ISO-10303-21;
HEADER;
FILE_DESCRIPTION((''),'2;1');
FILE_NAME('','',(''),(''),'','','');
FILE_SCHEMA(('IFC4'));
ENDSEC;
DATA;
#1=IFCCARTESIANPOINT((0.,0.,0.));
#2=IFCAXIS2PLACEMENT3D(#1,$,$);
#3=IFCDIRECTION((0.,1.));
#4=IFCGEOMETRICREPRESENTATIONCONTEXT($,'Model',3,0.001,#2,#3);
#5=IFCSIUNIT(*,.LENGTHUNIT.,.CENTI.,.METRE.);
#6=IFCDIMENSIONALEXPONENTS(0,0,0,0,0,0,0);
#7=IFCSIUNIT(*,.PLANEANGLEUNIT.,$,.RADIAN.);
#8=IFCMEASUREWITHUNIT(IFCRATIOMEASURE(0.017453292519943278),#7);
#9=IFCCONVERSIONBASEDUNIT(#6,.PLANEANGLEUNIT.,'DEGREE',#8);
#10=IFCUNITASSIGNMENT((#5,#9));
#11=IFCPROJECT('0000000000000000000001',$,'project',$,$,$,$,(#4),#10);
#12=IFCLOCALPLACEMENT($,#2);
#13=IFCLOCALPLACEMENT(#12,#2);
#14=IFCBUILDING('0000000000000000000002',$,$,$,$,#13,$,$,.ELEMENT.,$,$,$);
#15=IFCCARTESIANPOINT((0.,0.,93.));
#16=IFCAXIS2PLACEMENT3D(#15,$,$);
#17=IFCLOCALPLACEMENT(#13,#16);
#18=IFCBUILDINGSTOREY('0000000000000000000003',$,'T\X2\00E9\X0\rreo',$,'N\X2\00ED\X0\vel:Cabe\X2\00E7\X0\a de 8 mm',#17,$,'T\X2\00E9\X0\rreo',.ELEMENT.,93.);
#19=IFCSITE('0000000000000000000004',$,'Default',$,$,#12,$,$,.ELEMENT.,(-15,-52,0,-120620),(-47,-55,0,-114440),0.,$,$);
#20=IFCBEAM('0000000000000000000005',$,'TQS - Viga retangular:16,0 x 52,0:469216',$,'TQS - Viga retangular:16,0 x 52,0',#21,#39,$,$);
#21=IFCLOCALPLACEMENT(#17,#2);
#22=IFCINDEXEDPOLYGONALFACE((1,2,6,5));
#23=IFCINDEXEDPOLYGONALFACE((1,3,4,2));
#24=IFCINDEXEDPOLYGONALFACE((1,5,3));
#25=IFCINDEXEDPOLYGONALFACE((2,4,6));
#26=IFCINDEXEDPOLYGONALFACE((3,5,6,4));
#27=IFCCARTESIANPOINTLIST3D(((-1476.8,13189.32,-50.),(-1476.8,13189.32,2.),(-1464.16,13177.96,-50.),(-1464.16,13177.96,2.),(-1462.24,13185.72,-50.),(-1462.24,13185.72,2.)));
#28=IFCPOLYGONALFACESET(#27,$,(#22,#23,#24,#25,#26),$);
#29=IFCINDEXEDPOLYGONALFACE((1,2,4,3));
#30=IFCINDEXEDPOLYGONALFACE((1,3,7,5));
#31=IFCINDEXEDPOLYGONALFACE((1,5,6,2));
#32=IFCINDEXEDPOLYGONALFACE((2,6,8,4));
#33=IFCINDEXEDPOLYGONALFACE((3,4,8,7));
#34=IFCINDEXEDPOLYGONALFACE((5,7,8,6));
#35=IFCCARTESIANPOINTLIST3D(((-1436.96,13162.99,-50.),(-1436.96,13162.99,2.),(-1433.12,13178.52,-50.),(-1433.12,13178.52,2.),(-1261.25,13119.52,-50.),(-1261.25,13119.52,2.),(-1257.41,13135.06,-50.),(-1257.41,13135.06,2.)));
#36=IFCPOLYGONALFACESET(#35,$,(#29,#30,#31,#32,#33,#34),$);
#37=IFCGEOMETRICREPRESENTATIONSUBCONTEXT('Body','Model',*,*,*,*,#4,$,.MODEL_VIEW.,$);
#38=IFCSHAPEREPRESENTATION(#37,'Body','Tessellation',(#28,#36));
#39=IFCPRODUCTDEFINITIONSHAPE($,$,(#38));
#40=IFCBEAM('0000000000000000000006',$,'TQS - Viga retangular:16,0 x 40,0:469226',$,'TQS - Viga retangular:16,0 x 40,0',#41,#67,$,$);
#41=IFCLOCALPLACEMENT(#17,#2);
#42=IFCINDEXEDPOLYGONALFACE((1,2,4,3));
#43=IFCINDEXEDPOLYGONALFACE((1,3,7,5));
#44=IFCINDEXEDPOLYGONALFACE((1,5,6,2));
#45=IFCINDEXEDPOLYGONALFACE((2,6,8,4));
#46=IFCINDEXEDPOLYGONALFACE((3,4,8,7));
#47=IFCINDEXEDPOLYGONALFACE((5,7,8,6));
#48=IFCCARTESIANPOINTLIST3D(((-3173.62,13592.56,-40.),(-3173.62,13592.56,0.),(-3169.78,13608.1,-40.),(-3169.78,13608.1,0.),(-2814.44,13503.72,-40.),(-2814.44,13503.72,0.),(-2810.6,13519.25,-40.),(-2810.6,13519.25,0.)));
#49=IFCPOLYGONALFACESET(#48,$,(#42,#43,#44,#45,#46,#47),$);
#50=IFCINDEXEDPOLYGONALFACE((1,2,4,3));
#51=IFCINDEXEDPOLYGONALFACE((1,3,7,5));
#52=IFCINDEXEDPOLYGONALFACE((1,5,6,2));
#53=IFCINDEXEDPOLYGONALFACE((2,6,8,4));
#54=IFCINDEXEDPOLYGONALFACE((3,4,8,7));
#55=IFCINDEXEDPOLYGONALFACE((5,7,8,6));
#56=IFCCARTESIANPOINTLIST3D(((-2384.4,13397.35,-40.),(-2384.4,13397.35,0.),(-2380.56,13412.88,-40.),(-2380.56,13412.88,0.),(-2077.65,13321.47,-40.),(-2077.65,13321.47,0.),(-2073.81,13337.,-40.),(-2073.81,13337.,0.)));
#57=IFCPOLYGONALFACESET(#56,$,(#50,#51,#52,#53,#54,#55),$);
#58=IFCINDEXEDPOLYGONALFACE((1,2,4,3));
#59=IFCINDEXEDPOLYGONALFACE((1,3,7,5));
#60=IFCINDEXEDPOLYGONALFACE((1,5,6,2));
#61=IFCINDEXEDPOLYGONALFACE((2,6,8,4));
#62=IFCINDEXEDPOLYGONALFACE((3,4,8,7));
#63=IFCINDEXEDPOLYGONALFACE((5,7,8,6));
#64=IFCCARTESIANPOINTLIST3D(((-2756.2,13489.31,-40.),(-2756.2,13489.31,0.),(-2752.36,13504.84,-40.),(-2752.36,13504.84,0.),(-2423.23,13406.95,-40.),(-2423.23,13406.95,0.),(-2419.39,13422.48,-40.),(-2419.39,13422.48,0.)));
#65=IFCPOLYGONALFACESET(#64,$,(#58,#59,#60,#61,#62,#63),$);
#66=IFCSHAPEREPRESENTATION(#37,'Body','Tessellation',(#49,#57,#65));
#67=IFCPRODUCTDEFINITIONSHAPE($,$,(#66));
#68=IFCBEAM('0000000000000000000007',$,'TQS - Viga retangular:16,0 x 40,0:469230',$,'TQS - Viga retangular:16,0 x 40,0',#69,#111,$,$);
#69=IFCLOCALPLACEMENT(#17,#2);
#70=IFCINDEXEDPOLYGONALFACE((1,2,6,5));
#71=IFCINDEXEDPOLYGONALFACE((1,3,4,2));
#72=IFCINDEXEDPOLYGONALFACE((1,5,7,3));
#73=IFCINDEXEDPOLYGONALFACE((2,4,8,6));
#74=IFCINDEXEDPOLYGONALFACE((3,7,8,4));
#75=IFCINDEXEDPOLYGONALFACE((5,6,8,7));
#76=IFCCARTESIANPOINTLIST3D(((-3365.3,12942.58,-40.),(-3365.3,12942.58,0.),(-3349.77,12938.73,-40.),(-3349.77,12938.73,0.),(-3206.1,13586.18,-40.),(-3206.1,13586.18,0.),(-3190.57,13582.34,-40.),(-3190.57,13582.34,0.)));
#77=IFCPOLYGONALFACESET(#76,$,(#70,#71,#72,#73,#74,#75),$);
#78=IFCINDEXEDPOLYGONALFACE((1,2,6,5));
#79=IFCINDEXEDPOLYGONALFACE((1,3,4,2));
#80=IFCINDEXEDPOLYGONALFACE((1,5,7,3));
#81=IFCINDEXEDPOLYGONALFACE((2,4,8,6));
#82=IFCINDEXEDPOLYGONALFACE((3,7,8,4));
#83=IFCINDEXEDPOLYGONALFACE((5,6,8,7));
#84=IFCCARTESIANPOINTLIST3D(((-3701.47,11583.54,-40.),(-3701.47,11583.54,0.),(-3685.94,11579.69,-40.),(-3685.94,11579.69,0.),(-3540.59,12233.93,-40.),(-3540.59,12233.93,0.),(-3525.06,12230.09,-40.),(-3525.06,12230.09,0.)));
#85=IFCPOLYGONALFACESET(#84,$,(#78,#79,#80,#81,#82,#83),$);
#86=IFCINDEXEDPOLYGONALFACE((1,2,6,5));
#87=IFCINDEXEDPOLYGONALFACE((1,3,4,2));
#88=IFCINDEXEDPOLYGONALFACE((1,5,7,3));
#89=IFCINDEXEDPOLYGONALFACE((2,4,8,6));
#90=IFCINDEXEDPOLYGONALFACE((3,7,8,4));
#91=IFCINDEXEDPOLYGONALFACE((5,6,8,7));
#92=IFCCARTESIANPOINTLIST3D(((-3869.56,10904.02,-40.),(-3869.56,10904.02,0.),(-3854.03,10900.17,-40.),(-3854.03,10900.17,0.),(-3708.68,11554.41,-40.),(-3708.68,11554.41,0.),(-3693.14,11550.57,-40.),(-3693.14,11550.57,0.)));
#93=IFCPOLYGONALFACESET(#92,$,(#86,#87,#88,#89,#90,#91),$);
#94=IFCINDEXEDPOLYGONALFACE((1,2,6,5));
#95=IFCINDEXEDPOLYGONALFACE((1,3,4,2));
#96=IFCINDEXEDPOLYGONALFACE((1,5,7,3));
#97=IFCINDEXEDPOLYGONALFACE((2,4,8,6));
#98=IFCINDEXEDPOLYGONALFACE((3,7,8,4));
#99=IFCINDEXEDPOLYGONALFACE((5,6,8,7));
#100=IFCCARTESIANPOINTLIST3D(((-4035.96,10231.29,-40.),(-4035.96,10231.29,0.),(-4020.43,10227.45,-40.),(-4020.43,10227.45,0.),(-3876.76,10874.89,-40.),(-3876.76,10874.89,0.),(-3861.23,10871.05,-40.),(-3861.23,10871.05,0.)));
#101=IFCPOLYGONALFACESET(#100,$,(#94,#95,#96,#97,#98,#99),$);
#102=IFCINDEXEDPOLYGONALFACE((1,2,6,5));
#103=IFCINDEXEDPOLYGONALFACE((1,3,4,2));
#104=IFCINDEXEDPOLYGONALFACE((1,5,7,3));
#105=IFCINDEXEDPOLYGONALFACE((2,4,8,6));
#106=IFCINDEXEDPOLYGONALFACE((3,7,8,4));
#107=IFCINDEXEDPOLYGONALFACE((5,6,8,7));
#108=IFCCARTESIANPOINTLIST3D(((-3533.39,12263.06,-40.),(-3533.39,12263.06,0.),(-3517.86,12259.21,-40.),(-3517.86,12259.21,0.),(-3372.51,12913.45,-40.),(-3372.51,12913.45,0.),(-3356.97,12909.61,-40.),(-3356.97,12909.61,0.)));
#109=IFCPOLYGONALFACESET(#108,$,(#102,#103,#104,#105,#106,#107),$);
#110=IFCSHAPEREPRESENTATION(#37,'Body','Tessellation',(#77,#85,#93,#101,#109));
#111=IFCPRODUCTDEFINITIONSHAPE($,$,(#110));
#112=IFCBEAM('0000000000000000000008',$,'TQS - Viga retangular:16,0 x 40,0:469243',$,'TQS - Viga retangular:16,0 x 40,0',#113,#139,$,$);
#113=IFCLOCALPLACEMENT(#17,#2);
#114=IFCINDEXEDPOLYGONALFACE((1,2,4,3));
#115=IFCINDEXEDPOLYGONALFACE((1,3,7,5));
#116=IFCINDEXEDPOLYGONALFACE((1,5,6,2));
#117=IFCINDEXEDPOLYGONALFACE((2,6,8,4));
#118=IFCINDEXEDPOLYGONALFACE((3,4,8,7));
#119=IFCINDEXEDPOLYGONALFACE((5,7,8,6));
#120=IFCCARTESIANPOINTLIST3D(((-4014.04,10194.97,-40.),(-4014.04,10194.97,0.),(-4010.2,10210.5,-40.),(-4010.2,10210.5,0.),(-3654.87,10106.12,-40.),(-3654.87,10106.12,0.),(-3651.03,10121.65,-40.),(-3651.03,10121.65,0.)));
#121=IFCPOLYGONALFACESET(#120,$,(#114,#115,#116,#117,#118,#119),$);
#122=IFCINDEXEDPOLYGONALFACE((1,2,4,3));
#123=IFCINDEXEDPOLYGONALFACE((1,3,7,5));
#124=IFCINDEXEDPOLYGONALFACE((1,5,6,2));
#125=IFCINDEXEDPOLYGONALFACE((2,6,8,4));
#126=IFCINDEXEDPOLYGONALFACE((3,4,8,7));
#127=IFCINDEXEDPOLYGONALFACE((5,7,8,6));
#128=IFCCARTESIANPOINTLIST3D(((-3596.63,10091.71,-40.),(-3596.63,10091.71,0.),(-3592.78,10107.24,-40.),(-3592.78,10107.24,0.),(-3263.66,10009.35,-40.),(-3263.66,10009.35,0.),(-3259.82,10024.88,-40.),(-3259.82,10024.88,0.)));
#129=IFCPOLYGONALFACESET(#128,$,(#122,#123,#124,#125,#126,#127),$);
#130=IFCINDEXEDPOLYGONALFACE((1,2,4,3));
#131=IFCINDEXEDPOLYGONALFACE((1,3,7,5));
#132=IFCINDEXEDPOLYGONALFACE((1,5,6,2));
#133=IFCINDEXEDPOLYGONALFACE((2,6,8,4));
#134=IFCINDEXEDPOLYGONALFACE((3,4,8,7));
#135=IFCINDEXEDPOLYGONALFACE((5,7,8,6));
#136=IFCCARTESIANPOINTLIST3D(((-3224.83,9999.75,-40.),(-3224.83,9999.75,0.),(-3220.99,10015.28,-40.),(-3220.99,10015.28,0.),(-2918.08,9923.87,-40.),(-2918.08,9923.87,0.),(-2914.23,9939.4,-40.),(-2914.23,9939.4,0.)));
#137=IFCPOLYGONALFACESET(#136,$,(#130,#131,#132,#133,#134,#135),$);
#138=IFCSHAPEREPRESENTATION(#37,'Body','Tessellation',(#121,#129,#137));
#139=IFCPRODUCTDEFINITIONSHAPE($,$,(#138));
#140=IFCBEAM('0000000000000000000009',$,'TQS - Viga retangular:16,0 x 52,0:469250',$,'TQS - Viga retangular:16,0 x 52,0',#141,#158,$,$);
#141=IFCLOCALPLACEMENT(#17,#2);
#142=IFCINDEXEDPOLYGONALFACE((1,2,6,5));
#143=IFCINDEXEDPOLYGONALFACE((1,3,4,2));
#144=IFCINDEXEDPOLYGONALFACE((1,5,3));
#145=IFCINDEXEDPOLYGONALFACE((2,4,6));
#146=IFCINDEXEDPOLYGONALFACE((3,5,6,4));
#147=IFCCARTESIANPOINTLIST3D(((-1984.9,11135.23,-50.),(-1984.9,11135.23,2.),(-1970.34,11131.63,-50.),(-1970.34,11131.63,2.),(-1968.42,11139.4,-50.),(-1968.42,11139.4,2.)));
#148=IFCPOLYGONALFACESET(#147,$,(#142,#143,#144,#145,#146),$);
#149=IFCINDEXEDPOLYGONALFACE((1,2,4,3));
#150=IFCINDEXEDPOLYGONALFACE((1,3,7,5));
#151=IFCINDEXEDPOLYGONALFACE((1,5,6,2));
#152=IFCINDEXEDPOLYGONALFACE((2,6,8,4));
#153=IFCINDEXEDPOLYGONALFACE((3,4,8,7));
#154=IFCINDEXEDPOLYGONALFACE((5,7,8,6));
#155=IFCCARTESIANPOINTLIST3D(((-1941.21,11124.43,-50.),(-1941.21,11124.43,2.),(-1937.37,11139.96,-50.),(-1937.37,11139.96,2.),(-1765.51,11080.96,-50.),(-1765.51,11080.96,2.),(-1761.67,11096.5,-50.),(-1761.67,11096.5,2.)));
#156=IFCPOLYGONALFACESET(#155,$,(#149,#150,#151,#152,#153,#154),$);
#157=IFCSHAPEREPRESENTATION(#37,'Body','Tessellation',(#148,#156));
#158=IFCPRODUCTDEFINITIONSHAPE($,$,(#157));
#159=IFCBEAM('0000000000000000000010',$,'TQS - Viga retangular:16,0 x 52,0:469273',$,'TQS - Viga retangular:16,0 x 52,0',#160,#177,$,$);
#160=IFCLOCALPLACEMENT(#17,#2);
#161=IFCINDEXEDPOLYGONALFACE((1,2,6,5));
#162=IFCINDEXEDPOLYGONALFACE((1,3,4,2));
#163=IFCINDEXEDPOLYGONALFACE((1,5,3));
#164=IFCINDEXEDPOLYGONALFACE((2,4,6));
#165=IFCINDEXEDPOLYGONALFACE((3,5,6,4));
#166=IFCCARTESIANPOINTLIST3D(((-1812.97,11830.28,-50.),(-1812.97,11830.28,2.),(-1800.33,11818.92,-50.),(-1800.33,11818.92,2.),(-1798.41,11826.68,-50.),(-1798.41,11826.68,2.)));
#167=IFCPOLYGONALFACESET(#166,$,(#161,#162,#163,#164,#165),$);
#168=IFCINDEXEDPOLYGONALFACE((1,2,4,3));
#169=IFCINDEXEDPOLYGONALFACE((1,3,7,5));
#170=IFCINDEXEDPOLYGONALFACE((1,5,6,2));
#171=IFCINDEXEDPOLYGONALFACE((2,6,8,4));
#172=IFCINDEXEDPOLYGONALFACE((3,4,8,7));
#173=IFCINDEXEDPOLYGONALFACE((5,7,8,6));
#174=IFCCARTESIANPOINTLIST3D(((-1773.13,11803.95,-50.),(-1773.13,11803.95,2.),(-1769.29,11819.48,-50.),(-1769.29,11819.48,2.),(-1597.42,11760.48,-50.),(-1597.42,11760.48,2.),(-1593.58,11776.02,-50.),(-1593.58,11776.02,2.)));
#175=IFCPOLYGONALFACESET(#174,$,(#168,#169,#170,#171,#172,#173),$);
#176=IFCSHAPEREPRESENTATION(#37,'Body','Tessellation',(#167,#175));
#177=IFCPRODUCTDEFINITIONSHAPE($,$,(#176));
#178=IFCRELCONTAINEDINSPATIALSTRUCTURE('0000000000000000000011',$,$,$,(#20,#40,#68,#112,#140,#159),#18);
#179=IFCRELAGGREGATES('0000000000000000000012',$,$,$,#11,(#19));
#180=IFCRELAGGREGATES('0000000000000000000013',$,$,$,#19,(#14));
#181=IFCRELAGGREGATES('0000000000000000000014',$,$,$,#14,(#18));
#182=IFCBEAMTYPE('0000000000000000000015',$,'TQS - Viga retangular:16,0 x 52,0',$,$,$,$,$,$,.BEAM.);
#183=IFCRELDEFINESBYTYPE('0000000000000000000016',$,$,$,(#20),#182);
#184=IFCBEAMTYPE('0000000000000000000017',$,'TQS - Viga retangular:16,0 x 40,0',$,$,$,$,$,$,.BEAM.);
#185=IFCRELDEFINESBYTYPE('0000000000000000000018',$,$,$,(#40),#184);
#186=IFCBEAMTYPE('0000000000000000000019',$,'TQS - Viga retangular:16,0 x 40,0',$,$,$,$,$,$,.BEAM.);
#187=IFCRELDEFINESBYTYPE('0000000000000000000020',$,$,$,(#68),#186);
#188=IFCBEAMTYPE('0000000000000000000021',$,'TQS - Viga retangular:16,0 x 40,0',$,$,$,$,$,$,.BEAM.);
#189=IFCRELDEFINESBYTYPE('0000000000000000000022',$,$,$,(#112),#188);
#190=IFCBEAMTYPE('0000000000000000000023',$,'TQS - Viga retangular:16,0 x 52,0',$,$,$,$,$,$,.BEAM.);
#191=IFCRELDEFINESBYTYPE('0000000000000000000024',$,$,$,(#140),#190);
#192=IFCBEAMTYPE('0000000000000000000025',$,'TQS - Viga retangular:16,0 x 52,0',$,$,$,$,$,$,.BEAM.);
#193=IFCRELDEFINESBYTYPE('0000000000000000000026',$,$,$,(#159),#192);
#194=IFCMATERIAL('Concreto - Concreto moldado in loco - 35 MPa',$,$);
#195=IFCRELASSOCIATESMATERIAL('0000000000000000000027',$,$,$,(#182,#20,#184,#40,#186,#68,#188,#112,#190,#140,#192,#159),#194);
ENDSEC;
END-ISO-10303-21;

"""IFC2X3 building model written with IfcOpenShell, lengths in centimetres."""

from ifc_helpers import new_model, entity, si_unit, converted_unit, direction, frame, frame_2d, origin, place, context, subcontext, project, spatial, rectangle, extrude, clip, halfspace, source, transform, mapped, material, type_object, type_shapes, element, save


model = new_model("IFC2X3")

# Units and contexts
model_context = context("Model", 3, precision=0.001, world=origin(), true_north=direction((0.0, 1.0)))
body_context = subcontext(model_context, "Body", "Model", "MODEL_VIEW")
ifc_project = project(units=[si_unit("LENGTHUNIT", "METRE", prefix="CENTI"), converted_unit("PLANEANGLEUNIT", "DEGREE", entity("IfcRatioMeasure", 0.017453292519943278), si_unit("PLANEANGLEUNIT", "RADIAN"), dimensions=[0, 0, 0, 0, 0, 0, 0])], contexts=[model_context])

# Site, building, storey
site_placement = place(None, origin())
site = spatial("IfcSite", under=ifc_project, at=site_placement, Name="Default", CompositionType="ELEMENT", RefLatitude=(-15, -52, 0, -120620), RefLongitude=(-47, -55, 0, -114440), RefElevation=0.0)
building_placement = place(site_placement, origin())
building = spatial("IfcBuilding", under=site, at=building_placement, CompositionType="ELEMENT")
storey_placement = place(building_placement, frame((0.0, 0.0, 93.0)))
storey = spatial("IfcBuildingStorey", under=building, at=storey_placement, Name="Térreo", ObjectType="Nível:Cabeça de 8 mm", LongName="Térreo", CompositionType="ELEMENT", Elevation=93.0)

# Beams
ifc_material = material(Name="Concreto - Concreto moldado in loco - 35 MPa")
beam_type_1 = type_object("IfcBeamType", Name="TQS - Viga retangular:16,0 x 52,0", PredefinedType="BEAM", material=ifc_material)
shared_shape_1 = source(origin(), body_context, "Body", "SweptSolid", [
    clip(extrude(rectangle(XDim=52.0, YDim=8.0, at=frame_2d((0.0, 0.0), x_axis=(0.0, 1.0))), frame((-1463.2, 13181.84, 69.0), z_axis=(-0.970743, 0.240122, 0.0), x_axis=(0.240122, 0.970743, 0.0)), (0.0, 0.0, 1.0), 15.0), halfspace(frame((-1451.52, 13166.59, 95.0), z_axis=(-0.668693, -0.743539, 0.0), x_axis=(0.743539, -0.668693, 0.0)), False)),
    extrude(rectangle(XDim=52.0, YDim=16.0, at=frame_2d((0.0, 0.0), x_axis=(1.0, 0.0))), frame((-1259.33, 13127.29, 69.0), z_axis=(-0.970743, 0.240122, 0.0), x_axis=(0.0, 0.0, 1.0)), (0.0, 0.0, 1.0), 181.0),
])
type_shapes(beam_type_1, [shared_shape_1])
beam_1_placement = place(storey_placement, frame((0.0, 0.0, -93.0)))
element("IfcBeam", 1, at=beam_1_placement, inside=storey, type_object=beam_type_1, material=ifc_material, Name="TQS - Viga retangular:16,0 x 52,0:469216", ObjectType="TQS - Viga retangular:16,0 x 52,0", context=body_context, shape_type="MappedRepresentation", body=[
    mapped(shared_shape_1, transform((0.0, 0.0, 0.0), scale=1.0)),
])
beam_type_2 = type_object("IfcBeamType", Name="TQS - Viga retangular:16,0 x 40,0", PredefinedType="BEAM", material=ifc_material)
shared_shape_2 = source(origin(), body_context, "Body", "SweptSolid", [
    extrude(rectangle(XDim=40.0, YDim=16.0, at=frame_2d((0.0, 0.0), x_axis=(1.0, 0.0))), frame((-2812.52, 13511.49, 73.0), z_axis=(-0.970743, 0.240122, 0.0), x_axis=(0.0, 0.0, 1.0)), (0.0, 0.0, 1.0), 370.0),
    extrude(rectangle(XDim=40.0, YDim=16.0, at=frame_2d((0.0, 0.0), x_axis=(1.0, 0.0))), frame((-2075.73, 13329.23, 73.0), z_axis=(-0.970743, 0.240122, 0.0), x_axis=(0.0, 0.0, 1.0)), (0.0, 0.0, 1.0), 316.0),
    extrude(rectangle(XDim=40.0, YDim=16.0, at=frame_2d((0.0, 0.0), x_axis=(1.0, 0.0))), frame((-2421.31, 13414.72, 73.0), z_axis=(-0.970743, 0.240122, 0.0), x_axis=(0.0, 0.0, 1.0)), (0.0, 0.0, 1.0), 343.0),
])
type_shapes(beam_type_2, [shared_shape_2])
beam_2_placement = place(storey_placement, frame((0.0, 0.0, -93.0)))
element("IfcBeam", 2, at=beam_2_placement, inside=storey, type_object=beam_type_2, material=ifc_material, Name="TQS - Viga retangular:16,0 x 40,0:469226", ObjectType="TQS - Viga retangular:16,0 x 40,0", context=body_context, shape_type="MappedRepresentation", body=[
    mapped(shared_shape_2, transform((0.0, 0.0, 0.0), scale=1.0)),
])
beam_type_3 = type_object("IfcBeamType", Name="TQS - Viga retangular:16,0 x 40,0", PredefinedType="BEAM", material=ifc_material)
shared_shape_3 = source(origin(), body_context, "Body", "SweptSolid", [
    extrude(rectangle(XDim=40.0, YDim=16.0, at=frame_2d((0.0, 0.0), x_axis=(1.0, 0.0))), frame((-3357.54, 12940.65, 73.0), z_axis=(0.240122, 0.970743, 0.0), x_axis=(0.0, 0.0, 1.0)), (0.0, 0.0, 1.0), 663.0),
    extrude(rectangle(XDim=40.0, YDim=16.0, at=frame_2d((0.0, 0.0), x_axis=(1.0, 0.0))), frame((-3693.71, 11581.61, 73.0), z_axis=(0.240122, 0.970743, 0.0), x_axis=(0.0, 0.0, 1.0)), (0.0, 0.0, 1.0), 670.0),
    extrude(rectangle(XDim=40.0, YDim=16.0, at=frame_2d((0.0, 0.0), x_axis=(1.0, 0.0))), frame((-3861.79, 10902.09, 73.0), z_axis=(0.240122, 0.970743, 0.0), x_axis=(0.0, 0.0, 1.0)), (0.0, 0.0, 1.0), 670.0),
    extrude(rectangle(XDim=40.0, YDim=16.0, at=frame_2d((0.0, 0.0), x_axis=(1.0, 0.0))), frame((-4028.2, 10229.37, 73.0), z_axis=(0.240122, 0.970743, 0.0), x_axis=(0.0, 0.0, 1.0)), (0.0, 0.0, 1.0), 663.0),
    extrude(rectangle(XDim=40.0, YDim=16.0, at=frame_2d((0.0, 0.0), x_axis=(1.0, 0.0))), frame((-3525.62, 12261.13, 73.0), z_axis=(0.240122, 0.970743, 0.0), x_axis=(0.0, 0.0, 1.0)), (0.0, 0.0, 1.0), 670.0),
])
type_shapes(beam_type_3, [shared_shape_3])
beam_3_placement = place(storey_placement, frame((0.0, 0.0, -93.0)))
element("IfcBeam", 3, at=beam_3_placement, inside=storey, type_object=beam_type_3, material=ifc_material, Name="TQS - Viga retangular:16,0 x 40,0:469230", ObjectType="TQS - Viga retangular:16,0 x 40,0", context=body_context, shape_type="MappedRepresentation", body=[
    mapped(shared_shape_3, transform((0.0, 0.0, 0.0), scale=1.0)),
])
beam_type_4 = type_object("IfcBeamType", Name="TQS - Viga retangular:16,0 x 40,0", PredefinedType="BEAM", material=ifc_material)
shared_shape_4 = source(origin(), body_context, "Body", "SweptSolid", [
    extrude(rectangle(XDim=40.0, YDim=16.0, at=frame_2d((0.0, 0.0), x_axis=(1.0, 0.0))), frame((-3652.95, 10113.89, 73.0), z_axis=(-0.970743, 0.240122, 0.0), x_axis=(0.0, 0.0, 1.0)), (0.0, 0.0, 1.0), 370.0),
    extrude(rectangle(XDim=40.0, YDim=16.0, at=frame_2d((0.0, 0.0), x_axis=(1.0, 0.0))), frame((-3261.74, 10017.12, 73.0), z_axis=(-0.970743, 0.240122, 0.0), x_axis=(0.0, 0.0, 1.0)), (0.0, 0.0, 1.0), 343.0),
    extrude(rectangle(XDim=40.0, YDim=16.0, at=frame_2d((0.0, 0.0), x_axis=(1.0, 0.0))), frame((-2916.16, 9931.63, 73.0), z_axis=(-0.970743, 0.240122, 0.0), x_axis=(0.0, 0.0, 1.0)), (0.0, 0.0, 1.0), 316.0),
])
type_shapes(beam_type_4, [shared_shape_4])
beam_4_placement = place(storey_placement, frame((0.0, 0.0, -93.0)))
element("IfcBeam", 4, at=beam_4_placement, inside=storey, type_object=beam_type_4, material=ifc_material, Name="TQS - Viga retangular:16,0 x 40,0:469243", ObjectType="TQS - Viga retangular:16,0 x 40,0", context=body_context, shape_type="MappedRepresentation", body=[
    mapped(shared_shape_4, transform((0.0, 0.0, 0.0), scale=1.0)),
])
beam_type_5 = type_object("IfcBeamType", Name="TQS - Viga retangular:16,0 x 52,0", PredefinedType="BEAM", material=ifc_material)
shared_shape_5 = source(origin(), body_context, "Body", "SweptSolid", [
    clip(extrude(rectangle(XDim=52.0, YDim=8.0, at=frame_2d((0.0, 0.0), x_axis=(1.0, 0.0))), frame((-1969.38, 11135.51, 69.0), z_axis=(-0.970743, 0.240122, 0.0), x_axis=(0.0, 0.0, 1.0)), (0.0, 0.0, 1.0), 15.0), halfspace(frame((-1951.93, 11143.56, 95.0), z_axis=(-0.244948, 0.969536, 0.0), x_axis=(0.969536, 0.244948, 0.0)), False)),
    extrude(rectangle(XDim=52.0, YDim=16.0, at=frame_2d((0.0, 0.0), x_axis=(1.0, 0.0))), frame((-1763.59, 11088.73, 69.0), z_axis=(-0.970743, 0.240122, 0.0), x_axis=(0.0, 0.0, 1.0)), (0.0, 0.0, 1.0), 181.0),
])
type_shapes(beam_type_5, [shared_shape_5])
beam_5_placement = place(storey_placement, frame((0.0, 0.0, -93.0)))
element("IfcBeam", 5, at=beam_5_placement, inside=storey, type_object=beam_type_5, material=ifc_material, Name="TQS - Viga retangular:16,0 x 52,0:469250", ObjectType="TQS - Viga retangular:16,0 x 52,0", context=body_context, shape_type="MappedRepresentation", body=[
    mapped(shared_shape_5, transform((0.0, 0.0, 0.0), scale=1.0)),
])
beam_type_6 = type_object("IfcBeamType", Name="TQS - Viga retangular:16,0 x 52,0", PredefinedType="BEAM", material=ifc_material)
shared_shape_6 = source(origin(), body_context, "Body", "SweptSolid", [
    clip(extrude(rectangle(XDim=52.0, YDim=8.0, at=frame_2d((0.0, 0.0), x_axis=(0.0, 1.0))), frame((-1799.37, 11822.8, 69.0), z_axis=(-0.970743, 0.240122, 0.0), x_axis=(0.240122, 0.970743, 0.0)), (0.0, 0.0, 1.0), 15.0), halfspace(frame((-1787.69, 11807.55, 95.0), z_axis=(-0.668693, -0.743539, 0.0), x_axis=(0.743539, -0.668693, 0.0)), False)),
    extrude(rectangle(XDim=52.0, YDim=16.0, at=frame_2d((0.0, 0.0), x_axis=(1.0, 0.0))), frame((-1595.5, 11768.25, 69.0), z_axis=(-0.970743, 0.240122, 0.0), x_axis=(0.0, 0.0, 1.0)), (0.0, 0.0, 1.0), 181.0),
])
type_shapes(beam_type_6, [shared_shape_6])
beam_6_placement = place(storey_placement, frame((0.0, 0.0, -93.0)))
element("IfcBeam", 6, at=beam_6_placement, inside=storey, type_object=beam_type_6, material=ifc_material, Name="TQS - Viga retangular:16,0 x 52,0:469273", ObjectType="TQS - Viga retangular:16,0 x 52,0", context=body_context, shape_type="MappedRepresentation", body=[
    mapped(shared_shape_6, transform((0.0, 0.0, 0.0), scale=1.0)),
])

save(model, "model.ifc")
